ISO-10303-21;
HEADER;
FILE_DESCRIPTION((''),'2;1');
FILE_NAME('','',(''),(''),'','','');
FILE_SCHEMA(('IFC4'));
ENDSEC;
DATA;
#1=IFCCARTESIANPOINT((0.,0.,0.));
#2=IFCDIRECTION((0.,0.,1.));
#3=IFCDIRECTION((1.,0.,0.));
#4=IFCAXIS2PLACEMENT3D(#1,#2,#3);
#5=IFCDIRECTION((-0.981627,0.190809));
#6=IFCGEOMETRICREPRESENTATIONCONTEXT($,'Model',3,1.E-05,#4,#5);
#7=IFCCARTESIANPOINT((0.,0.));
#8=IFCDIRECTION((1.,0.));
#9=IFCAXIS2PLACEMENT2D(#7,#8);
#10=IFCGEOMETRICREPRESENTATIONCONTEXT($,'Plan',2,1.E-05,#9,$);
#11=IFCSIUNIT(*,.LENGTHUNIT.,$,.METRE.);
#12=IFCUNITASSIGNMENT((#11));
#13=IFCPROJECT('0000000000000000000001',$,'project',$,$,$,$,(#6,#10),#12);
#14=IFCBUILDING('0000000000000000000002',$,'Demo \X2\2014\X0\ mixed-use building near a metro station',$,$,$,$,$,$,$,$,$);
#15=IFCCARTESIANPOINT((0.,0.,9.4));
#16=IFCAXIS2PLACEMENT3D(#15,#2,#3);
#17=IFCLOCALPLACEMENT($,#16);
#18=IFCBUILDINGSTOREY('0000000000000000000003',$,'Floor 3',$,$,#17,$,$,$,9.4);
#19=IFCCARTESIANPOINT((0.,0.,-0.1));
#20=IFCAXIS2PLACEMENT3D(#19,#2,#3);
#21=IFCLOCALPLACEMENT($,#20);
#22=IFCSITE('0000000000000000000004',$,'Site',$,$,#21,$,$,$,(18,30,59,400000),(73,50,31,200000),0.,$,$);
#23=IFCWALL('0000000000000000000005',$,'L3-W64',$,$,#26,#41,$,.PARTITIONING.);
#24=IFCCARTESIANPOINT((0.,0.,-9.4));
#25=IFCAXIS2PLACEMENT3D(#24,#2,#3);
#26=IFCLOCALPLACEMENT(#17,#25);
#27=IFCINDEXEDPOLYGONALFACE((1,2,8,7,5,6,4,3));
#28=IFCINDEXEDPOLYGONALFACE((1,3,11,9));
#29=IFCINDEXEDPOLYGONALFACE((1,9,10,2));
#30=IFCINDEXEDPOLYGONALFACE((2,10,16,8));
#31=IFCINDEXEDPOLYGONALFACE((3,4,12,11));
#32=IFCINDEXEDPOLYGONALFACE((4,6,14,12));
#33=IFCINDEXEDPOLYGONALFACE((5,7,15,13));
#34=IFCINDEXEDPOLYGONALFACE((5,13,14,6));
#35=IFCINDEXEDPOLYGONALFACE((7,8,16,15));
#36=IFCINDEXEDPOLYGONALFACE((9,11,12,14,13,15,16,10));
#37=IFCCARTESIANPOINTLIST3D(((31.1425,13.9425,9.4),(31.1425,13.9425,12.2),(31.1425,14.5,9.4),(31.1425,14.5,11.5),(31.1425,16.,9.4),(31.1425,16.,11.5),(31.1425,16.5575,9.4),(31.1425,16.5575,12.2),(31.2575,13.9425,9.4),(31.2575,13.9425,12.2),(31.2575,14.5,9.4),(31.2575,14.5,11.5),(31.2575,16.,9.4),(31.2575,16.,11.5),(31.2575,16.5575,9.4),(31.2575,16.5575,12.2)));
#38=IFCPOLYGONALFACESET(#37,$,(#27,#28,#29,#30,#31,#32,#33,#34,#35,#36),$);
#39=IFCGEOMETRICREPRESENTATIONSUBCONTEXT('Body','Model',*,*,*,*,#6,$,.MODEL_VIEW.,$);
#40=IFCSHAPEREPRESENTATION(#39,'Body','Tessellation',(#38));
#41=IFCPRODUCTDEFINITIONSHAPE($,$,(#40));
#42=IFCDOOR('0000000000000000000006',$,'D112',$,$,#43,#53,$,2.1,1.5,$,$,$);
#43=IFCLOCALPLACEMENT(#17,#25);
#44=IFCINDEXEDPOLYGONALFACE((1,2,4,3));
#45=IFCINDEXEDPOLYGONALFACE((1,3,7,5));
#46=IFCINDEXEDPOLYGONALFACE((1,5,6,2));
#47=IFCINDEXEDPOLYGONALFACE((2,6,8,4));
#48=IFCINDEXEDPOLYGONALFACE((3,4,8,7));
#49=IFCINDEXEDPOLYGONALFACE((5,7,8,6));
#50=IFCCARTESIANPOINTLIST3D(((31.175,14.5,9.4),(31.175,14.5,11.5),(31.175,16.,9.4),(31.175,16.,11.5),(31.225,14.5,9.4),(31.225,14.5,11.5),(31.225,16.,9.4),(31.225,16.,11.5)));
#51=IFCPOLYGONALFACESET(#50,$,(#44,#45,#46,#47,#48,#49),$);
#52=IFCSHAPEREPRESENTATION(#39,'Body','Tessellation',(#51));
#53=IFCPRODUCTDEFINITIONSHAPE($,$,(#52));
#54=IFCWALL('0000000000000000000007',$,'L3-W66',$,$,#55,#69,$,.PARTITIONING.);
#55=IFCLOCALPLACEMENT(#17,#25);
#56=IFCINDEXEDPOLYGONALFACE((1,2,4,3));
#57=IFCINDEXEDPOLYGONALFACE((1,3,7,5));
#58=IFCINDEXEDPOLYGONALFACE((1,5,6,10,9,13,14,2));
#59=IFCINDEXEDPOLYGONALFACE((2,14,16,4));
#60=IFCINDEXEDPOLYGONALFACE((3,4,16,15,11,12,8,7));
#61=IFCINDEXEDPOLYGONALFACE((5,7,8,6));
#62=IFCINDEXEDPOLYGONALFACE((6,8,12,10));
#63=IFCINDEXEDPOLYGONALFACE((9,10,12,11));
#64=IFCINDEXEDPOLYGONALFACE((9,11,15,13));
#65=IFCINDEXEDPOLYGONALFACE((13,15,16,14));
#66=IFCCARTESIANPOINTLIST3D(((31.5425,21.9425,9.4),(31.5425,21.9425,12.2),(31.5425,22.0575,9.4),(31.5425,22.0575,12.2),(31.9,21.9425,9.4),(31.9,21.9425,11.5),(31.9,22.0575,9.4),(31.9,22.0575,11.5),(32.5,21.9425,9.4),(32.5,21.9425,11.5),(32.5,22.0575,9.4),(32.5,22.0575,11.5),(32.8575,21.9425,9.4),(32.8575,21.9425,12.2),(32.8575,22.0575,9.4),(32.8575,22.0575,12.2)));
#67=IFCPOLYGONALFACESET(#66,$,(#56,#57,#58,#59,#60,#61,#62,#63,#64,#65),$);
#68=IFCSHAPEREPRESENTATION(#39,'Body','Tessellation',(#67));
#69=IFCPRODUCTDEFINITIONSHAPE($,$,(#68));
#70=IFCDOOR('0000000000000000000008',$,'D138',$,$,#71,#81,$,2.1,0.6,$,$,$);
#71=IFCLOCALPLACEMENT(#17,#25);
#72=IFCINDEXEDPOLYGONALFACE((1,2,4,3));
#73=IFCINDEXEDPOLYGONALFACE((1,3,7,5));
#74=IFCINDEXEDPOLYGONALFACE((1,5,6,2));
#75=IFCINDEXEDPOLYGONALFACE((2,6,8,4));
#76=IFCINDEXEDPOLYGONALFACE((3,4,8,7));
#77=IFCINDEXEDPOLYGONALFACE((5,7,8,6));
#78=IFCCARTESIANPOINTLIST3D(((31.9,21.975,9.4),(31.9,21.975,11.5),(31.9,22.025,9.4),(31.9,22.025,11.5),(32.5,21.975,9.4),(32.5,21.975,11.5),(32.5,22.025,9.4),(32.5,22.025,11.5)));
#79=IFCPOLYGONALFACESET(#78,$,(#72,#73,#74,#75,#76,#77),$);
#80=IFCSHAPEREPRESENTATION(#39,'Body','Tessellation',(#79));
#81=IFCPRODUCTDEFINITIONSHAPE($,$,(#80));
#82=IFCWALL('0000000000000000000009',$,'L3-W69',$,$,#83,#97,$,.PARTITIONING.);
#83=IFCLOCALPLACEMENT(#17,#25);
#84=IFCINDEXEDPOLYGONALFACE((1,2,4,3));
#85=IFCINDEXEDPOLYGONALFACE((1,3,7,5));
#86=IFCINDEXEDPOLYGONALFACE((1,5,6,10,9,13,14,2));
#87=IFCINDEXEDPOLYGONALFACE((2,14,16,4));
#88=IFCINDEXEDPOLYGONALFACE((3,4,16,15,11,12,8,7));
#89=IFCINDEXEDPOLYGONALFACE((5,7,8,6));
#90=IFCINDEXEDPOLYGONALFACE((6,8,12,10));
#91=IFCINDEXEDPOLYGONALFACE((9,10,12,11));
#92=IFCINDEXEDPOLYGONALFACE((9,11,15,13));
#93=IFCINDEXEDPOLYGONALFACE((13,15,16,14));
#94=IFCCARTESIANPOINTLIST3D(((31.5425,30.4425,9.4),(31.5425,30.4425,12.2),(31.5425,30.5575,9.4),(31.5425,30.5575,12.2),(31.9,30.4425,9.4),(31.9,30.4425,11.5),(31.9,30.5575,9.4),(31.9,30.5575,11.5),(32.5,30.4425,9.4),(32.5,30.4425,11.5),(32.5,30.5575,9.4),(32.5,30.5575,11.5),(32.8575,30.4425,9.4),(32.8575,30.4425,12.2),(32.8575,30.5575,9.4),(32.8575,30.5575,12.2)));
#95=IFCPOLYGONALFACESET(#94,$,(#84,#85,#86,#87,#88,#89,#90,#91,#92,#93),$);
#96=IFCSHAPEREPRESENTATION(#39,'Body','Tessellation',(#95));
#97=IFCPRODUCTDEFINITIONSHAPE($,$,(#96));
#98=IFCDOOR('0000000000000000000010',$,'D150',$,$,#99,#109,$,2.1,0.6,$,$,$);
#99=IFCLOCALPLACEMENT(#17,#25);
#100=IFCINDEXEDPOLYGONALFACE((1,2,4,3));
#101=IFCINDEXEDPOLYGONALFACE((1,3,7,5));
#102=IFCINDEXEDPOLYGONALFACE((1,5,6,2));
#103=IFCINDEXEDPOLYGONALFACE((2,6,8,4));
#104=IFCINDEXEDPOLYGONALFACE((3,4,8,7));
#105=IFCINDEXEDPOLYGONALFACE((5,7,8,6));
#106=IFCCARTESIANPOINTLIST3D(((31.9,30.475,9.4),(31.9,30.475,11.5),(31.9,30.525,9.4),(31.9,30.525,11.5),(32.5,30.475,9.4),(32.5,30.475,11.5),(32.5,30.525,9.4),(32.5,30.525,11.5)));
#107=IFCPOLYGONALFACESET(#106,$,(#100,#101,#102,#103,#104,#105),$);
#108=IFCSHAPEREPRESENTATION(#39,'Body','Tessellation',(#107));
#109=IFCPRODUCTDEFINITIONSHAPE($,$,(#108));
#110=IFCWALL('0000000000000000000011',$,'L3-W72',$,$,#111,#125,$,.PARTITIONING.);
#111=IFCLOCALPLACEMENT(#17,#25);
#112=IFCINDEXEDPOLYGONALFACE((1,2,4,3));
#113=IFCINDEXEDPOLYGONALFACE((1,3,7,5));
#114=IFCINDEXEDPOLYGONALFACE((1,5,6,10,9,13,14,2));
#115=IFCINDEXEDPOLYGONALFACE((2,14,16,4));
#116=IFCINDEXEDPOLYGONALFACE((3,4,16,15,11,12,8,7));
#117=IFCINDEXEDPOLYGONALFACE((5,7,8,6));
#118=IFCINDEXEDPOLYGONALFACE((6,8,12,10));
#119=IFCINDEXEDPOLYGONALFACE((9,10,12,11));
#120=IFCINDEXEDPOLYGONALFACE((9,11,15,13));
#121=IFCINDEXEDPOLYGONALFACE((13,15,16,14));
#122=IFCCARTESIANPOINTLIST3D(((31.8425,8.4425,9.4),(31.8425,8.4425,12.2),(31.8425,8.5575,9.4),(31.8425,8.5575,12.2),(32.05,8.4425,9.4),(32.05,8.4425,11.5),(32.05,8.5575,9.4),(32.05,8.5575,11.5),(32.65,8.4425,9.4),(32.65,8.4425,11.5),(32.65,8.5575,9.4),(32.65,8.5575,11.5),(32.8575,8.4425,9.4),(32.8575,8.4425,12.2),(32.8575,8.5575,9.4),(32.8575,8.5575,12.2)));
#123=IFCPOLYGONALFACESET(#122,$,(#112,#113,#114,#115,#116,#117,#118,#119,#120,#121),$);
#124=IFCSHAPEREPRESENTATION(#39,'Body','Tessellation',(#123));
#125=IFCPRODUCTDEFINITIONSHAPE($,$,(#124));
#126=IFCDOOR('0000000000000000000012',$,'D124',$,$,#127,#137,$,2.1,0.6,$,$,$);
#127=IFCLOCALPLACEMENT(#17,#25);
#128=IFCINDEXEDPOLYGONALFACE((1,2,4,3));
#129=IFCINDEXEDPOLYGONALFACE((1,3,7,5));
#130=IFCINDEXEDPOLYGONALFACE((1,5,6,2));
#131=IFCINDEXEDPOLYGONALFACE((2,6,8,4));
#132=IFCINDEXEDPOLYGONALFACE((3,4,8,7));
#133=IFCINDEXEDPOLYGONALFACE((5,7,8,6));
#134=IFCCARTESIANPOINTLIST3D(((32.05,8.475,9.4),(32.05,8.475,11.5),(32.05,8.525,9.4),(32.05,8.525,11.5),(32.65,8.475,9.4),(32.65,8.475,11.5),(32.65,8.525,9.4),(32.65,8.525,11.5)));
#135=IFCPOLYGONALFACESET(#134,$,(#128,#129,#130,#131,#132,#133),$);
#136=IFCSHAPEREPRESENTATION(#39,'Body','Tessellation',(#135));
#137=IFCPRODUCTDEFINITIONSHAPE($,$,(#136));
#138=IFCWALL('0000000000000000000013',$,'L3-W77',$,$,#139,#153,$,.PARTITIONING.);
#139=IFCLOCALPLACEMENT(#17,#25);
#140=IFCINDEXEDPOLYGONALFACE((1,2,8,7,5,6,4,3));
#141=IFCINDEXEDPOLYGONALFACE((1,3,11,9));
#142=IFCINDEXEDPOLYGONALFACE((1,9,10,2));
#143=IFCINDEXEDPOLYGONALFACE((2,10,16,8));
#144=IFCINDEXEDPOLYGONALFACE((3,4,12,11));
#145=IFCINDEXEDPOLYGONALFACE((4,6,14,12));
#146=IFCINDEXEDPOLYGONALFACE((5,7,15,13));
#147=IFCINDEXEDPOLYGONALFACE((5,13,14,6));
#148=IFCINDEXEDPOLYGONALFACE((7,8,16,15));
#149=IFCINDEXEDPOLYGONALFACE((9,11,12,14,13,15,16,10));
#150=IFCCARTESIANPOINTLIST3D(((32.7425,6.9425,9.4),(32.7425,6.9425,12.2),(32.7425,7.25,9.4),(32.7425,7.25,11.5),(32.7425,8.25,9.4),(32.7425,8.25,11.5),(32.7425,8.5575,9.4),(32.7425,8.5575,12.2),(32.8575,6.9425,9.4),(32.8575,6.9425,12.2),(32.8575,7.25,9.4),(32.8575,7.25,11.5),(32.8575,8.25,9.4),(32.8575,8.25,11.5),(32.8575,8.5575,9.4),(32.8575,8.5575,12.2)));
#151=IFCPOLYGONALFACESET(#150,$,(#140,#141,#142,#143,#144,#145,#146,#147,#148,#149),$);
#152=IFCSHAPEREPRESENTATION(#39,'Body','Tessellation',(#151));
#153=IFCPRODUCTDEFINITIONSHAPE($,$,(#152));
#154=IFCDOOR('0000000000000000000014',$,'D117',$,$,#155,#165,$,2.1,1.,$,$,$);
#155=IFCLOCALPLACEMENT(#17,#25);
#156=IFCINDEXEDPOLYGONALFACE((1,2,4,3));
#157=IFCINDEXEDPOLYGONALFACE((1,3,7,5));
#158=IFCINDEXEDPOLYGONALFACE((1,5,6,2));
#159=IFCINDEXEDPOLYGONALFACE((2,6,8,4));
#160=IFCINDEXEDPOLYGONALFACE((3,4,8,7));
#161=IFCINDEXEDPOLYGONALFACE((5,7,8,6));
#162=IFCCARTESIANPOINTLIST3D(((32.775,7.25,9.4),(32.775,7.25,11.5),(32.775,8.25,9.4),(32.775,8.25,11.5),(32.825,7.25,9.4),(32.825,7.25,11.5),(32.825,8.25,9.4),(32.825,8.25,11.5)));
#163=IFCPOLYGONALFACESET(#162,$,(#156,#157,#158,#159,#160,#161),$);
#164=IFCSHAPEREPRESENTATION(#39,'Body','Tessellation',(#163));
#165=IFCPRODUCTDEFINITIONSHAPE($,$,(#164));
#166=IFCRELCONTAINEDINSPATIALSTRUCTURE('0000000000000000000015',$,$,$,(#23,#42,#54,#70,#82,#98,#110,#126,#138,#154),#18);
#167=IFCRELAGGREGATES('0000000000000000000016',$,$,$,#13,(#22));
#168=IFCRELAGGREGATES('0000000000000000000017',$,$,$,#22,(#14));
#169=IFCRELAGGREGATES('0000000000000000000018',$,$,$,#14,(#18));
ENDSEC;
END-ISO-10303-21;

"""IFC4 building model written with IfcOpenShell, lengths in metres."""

from ifc_helpers import new_model, si_unit, direction, frame, origin_with_axes, origin_2d_with_axis, place, context, subcontext, project, spatial, line, indexed_curve, outline, extrude, element, fill, save


model = new_model("IFC4")

# Units and contexts
model_context = context("Model", 3, precision=1e-05, world=origin_with_axes(), true_north=direction((-0.981627, 0.190809)))
plan_context = context("Plan", 2, precision=1e-05, world=origin_2d_with_axis())
body_context = subcontext(model_context, "Body", "Model", "MODEL_VIEW")
ifc_project = project(units=[si_unit("LENGTHUNIT", "METRE")], contexts=[model_context, plan_context])

# Site, building, storey
site_placement = place(None, frame((0.0, 0.0, -0.1), z_axis=(0.0, 0.0, 1.0), x_axis=(1.0, 0.0, 0.0)))
site = spatial("IfcSite", under=ifc_project, at=site_placement, Name="Site", RefLatitude=(18, 30, 59, 400000), RefLongitude=(73, 50, 31, 200000), RefElevation=0.0)
building = spatial("IfcBuilding", under=site, Name="Demo — mixed-use building near a metro station")
storey_placement = place(None, frame((0.0, 0.0, 9.4), z_axis=(0.0, 0.0, 1.0), x_axis=(1.0, 0.0, 0.0)))
storey = spatial("IfcBuildingStorey", under=building, at=storey_placement, Name="Floor 3", Elevation=9.4)

# Wall, opening, door
wall_1_placement = place(storey_placement, frame((0.0, 0.0, -9.4), z_axis=(0.0, 0.0, 1.0), x_axis=(1.0, 0.0, 0.0)))
wall_1 = element("IfcWall", 1, at=wall_1_placement, inside=storey, Name="L3-W64", PredefinedType="PARTITIONING", context=body_context, shape_type="SweptSolid", body=[
    extrude(outline(indexed_curve([(31.1425, 13.9425), (31.1425, 16.5575), (31.2575, 16.5575), (31.2575, 13.9425)], segments=[line(1, 2, 3, 4, 1)])), frame((0.0, 0.0, 9.4), z_axis=(0.0, 0.0, 1.0), x_axis=(1.0, 0.0, 0.0)), (0.0, 0.0, 1.0), 2.8),
])
opening_1_placement = place(wall_1_placement, origin_with_axes())
opening_1 = element("IfcOpeningElement", 2, at=opening_1_placement, cuts=wall_1, context=body_context, shape_type="SweptSolid", body=[
    extrude(outline(indexed_curve([(31.0925, 14.5), (31.0925, 16.0), (31.3075, 16.0), (31.3075, 14.5)], segments=[line(1, 2, 3, 4, 1)])), frame((0.0, 0.0, 9.4), z_axis=(0.0, 0.0, 1.0), x_axis=(1.0, 0.0, 0.0)), (0.0, 0.0, 1.0), 2.1),
])
door_1_placement = place(storey_placement, frame((0.0, 0.0, -9.4), z_axis=(0.0, 0.0, 1.0), x_axis=(1.0, 0.0, 0.0)))
door_1 = element("IfcDoor", 3, at=door_1_placement, inside=storey, Name="D112", OverallHeight=2.1, OverallWidth=1.5, context=body_context, shape_type="SweptSolid", body=[
    extrude(outline(indexed_curve([(31.175, 14.5), (31.175, 16.0), (31.225, 16.0), (31.225, 14.5)], segments=[line(1, 2, 3, 4, 1)])), frame((0.0, 0.0, 9.4), z_axis=(0.0, 0.0, 1.0), x_axis=(1.0, 0.0, 0.0)), (0.0, 0.0, 1.0), 2.1),
])
fill(opening_1, door_1)

# Wall, opening, door
wall_2_placement = place(storey_placement, frame((0.0, 0.0, -9.4), z_axis=(0.0, 0.0, 1.0), x_axis=(1.0, 0.0, 0.0)))
wall_2 = element("IfcWall", 4, at=wall_2_placement, inside=storey, Name="L3-W66", PredefinedType="PARTITIONING", context=body_context, shape_type="SweptSolid", body=[
    extrude(outline(indexed_curve([(32.8575, 21.9425), (31.5425, 21.9425), (31.5425, 22.0575), (32.8575, 22.0575)], segments=[line(1, 2, 3, 4, 1)])), frame((0.0, 0.0, 9.4), z_axis=(0.0, 0.0, 1.0), x_axis=(1.0, 0.0, 0.0)), (0.0, 0.0, 1.0), 2.8),
])
opening_2_placement = place(wall_2_placement, origin_with_axes())
opening_2 = element("IfcOpeningElement", 5, at=opening_2_placement, cuts=wall_2, context=body_context, shape_type="SweptSolid", body=[
    extrude(outline(indexed_curve([(32.5, 21.8925), (31.9, 21.8925), (31.9, 22.1075), (32.5, 22.1075)], segments=[line(1, 2, 3, 4, 1)])), frame((0.0, 0.0, 9.4), z_axis=(0.0, 0.0, 1.0), x_axis=(1.0, 0.0, 0.0)), (0.0, 0.0, 1.0), 2.1),
])
door_2_placement = place(storey_placement, frame((0.0, 0.0, -9.4), z_axis=(0.0, 0.0, 1.0), x_axis=(1.0, 0.0, 0.0)))
door_2 = element("IfcDoor", 6, at=door_2_placement, inside=storey, Name="D138", OverallHeight=2.1, OverallWidth=0.6, context=body_context, shape_type="SweptSolid", body=[
    extrude(outline(indexed_curve([(32.5, 21.975), (31.9, 21.975), (31.9, 22.025), (32.5, 22.025)], segments=[line(1, 2, 3, 4, 1)])), frame((0.0, 0.0, 9.4), z_axis=(0.0, 0.0, 1.0), x_axis=(1.0, 0.0, 0.0)), (0.0, 0.0, 1.0), 2.1),
])
fill(opening_2, door_2)

# Wall, opening, door
wall_3_placement = place(storey_placement, frame((0.0, 0.0, -9.4), z_axis=(0.0, 0.0, 1.0), x_axis=(1.0, 0.0, 0.0)))
wall_3 = element("IfcWall", 7, at=wall_3_placement, inside=storey, Name="L3-W69", PredefinedType="PARTITIONING", context=body_context, shape_type="SweptSolid", body=[
    extrude(outline(indexed_curve([(32.8575, 30.4425), (31.5425, 30.4425), (31.5425, 30.5575), (32.8575, 30.5575)], segments=[line(1, 2, 3, 4, 1)])), frame((0.0, 0.0, 9.4), z_axis=(0.0, 0.0, 1.0), x_axis=(1.0, 0.0, 0.0)), (0.0, 0.0, 1.0), 2.8),
])
opening_3_placement = place(wall_3_placement, origin_with_axes())
opening_3 = element("IfcOpeningElement", 8, at=opening_3_placement, cuts=wall_3, context=body_context, shape_type="SweptSolid", body=[
    extrude(outline(indexed_curve([(32.5, 30.3925), (31.9, 30.3925), (31.9, 30.6075), (32.5, 30.6075)], segments=[line(1, 2, 3, 4, 1)])), frame((0.0, 0.0, 9.4), z_axis=(0.0, 0.0, 1.0), x_axis=(1.0, 0.0, 0.0)), (0.0, 0.0, 1.0), 2.1),
])
door_3_placement = place(storey_placement, frame((0.0, 0.0, -9.4), z_axis=(0.0, 0.0, 1.0), x_axis=(1.0, 0.0, 0.0)))
door_3 = element("IfcDoor", 9, at=door_3_placement, inside=storey, Name="D150", OverallHeight=2.1, OverallWidth=0.6, context=body_context, shape_type="SweptSolid", body=[
    extrude(outline(indexed_curve([(32.5, 30.475), (31.9, 30.475), (31.9, 30.525), (32.5, 30.525)], segments=[line(1, 2, 3, 4, 1)])), frame((0.0, 0.0, 9.4), z_axis=(0.0, 0.0, 1.0), x_axis=(1.0, 0.0, 0.0)), (0.0, 0.0, 1.0), 2.1),
])
fill(opening_3, door_3)

# Wall, opening, door
wall_4_placement = place(storey_placement, frame((0.0, 0.0, -9.4), z_axis=(0.0, 0.0, 1.0), x_axis=(1.0, 0.0, 0.0)))
wall_4 = element("IfcWall", 10, at=wall_4_placement, inside=storey, Name="L3-W72", PredefinedType="PARTITIONING", context=body_context, shape_type="SweptSolid", body=[
    extrude(outline(indexed_curve([(32.8575, 8.4425), (31.8425, 8.4425), (31.8425, 8.5575), (32.8575, 8.5575)], segments=[line(1, 2, 3, 4, 1)])), frame((0.0, 0.0, 9.4), z_axis=(0.0, 0.0, 1.0), x_axis=(1.0, 0.0, 0.0)), (0.0, 0.0, 1.0), 2.8),
])
opening_4_placement = place(wall_4_placement, origin_with_axes())
opening_4 = element("IfcOpeningElement", 11, at=opening_4_placement, cuts=wall_4, context=body_context, shape_type="SweptSolid", body=[
    extrude(outline(indexed_curve([(32.65, 8.3925), (32.05, 8.3925), (32.05, 8.6075), (32.65, 8.6075)], segments=[line(1, 2, 3, 4, 1)])), frame((0.0, 0.0, 9.4), z_axis=(0.0, 0.0, 1.0), x_axis=(1.0, 0.0, 0.0)), (0.0, 0.0, 1.0), 2.1),
])
door_4_placement = place(storey_placement, frame((0.0, 0.0, -9.4), z_axis=(0.0, 0.0, 1.0), x_axis=(1.0, 0.0, 0.0)))
door_4 = element("IfcDoor", 12, at=door_4_placement, inside=storey, Name="D124", OverallHeight=2.1, OverallWidth=0.6, context=body_context, shape_type="SweptSolid", body=[
    extrude(outline(indexed_curve([(32.65, 8.475), (32.05, 8.475), (32.05, 8.525), (32.65, 8.525)], segments=[line(1, 2, 3, 4, 1)])), frame((0.0, 0.0, 9.4), z_axis=(0.0, 0.0, 1.0), x_axis=(1.0, 0.0, 0.0)), (0.0, 0.0, 1.0), 2.1),
])
fill(opening_4, door_4)

# Wall, opening, door
wall_5_placement = place(storey_placement, frame((0.0, 0.0, -9.4), z_axis=(0.0, 0.0, 1.0), x_axis=(1.0, 0.0, 0.0)))
wall_5 = element("IfcWall", 13, at=wall_5_placement, inside=storey, Name="L3-W77", PredefinedType="PARTITIONING", context=body_context, shape_type="SweptSolid", body=[
    extrude(outline(indexed_curve([(32.8575, 8.5575), (32.8575, 6.9425), (32.7425, 6.9425), (32.7425, 8.5575)], segments=[line(1, 2, 3, 4, 1)])), frame((0.0, 0.0, 9.4), z_axis=(0.0, 0.0, 1.0), x_axis=(1.0, 0.0, 0.0)), (0.0, 0.0, 1.0), 2.8),
])
opening_5_placement = place(wall_5_placement, origin_with_axes())
opening_5 = element("IfcOpeningElement", 14, at=opening_5_placement, cuts=wall_5, context=body_context, shape_type="SweptSolid", body=[
    extrude(outline(indexed_curve([(32.9075, 8.25), (32.9075, 7.25), (32.6925, 7.25), (32.6925, 8.25)], segments=[line(1, 2, 3, 4, 1)])), frame((0.0, 0.0, 9.4), z_axis=(0.0, 0.0, 1.0), x_axis=(1.0, 0.0, 0.0)), (0.0, 0.0, 1.0), 2.1),
])
door_5_placement = place(storey_placement, frame((0.0, 0.0, -9.4), z_axis=(0.0, 0.0, 1.0), x_axis=(1.0, 0.0, 0.0)))
door_5 = element("IfcDoor", 15, at=door_5_placement, inside=storey, Name="D117", OverallHeight=2.1, OverallWidth=1.0, context=body_context, shape_type="SweptSolid", body=[
    extrude(outline(indexed_curve([(32.825, 8.25), (32.825, 7.25), (32.775, 7.25), (32.775, 8.25)], segments=[line(1, 2, 3, 4, 1)])), frame((0.0, 0.0, 9.4), z_axis=(0.0, 0.0, 1.0), x_axis=(1.0, 0.0, 0.0)), (0.0, 0.0, 1.0), 2.1),
])
fill(opening_5, door_5)

save(model, "model.ifc")
